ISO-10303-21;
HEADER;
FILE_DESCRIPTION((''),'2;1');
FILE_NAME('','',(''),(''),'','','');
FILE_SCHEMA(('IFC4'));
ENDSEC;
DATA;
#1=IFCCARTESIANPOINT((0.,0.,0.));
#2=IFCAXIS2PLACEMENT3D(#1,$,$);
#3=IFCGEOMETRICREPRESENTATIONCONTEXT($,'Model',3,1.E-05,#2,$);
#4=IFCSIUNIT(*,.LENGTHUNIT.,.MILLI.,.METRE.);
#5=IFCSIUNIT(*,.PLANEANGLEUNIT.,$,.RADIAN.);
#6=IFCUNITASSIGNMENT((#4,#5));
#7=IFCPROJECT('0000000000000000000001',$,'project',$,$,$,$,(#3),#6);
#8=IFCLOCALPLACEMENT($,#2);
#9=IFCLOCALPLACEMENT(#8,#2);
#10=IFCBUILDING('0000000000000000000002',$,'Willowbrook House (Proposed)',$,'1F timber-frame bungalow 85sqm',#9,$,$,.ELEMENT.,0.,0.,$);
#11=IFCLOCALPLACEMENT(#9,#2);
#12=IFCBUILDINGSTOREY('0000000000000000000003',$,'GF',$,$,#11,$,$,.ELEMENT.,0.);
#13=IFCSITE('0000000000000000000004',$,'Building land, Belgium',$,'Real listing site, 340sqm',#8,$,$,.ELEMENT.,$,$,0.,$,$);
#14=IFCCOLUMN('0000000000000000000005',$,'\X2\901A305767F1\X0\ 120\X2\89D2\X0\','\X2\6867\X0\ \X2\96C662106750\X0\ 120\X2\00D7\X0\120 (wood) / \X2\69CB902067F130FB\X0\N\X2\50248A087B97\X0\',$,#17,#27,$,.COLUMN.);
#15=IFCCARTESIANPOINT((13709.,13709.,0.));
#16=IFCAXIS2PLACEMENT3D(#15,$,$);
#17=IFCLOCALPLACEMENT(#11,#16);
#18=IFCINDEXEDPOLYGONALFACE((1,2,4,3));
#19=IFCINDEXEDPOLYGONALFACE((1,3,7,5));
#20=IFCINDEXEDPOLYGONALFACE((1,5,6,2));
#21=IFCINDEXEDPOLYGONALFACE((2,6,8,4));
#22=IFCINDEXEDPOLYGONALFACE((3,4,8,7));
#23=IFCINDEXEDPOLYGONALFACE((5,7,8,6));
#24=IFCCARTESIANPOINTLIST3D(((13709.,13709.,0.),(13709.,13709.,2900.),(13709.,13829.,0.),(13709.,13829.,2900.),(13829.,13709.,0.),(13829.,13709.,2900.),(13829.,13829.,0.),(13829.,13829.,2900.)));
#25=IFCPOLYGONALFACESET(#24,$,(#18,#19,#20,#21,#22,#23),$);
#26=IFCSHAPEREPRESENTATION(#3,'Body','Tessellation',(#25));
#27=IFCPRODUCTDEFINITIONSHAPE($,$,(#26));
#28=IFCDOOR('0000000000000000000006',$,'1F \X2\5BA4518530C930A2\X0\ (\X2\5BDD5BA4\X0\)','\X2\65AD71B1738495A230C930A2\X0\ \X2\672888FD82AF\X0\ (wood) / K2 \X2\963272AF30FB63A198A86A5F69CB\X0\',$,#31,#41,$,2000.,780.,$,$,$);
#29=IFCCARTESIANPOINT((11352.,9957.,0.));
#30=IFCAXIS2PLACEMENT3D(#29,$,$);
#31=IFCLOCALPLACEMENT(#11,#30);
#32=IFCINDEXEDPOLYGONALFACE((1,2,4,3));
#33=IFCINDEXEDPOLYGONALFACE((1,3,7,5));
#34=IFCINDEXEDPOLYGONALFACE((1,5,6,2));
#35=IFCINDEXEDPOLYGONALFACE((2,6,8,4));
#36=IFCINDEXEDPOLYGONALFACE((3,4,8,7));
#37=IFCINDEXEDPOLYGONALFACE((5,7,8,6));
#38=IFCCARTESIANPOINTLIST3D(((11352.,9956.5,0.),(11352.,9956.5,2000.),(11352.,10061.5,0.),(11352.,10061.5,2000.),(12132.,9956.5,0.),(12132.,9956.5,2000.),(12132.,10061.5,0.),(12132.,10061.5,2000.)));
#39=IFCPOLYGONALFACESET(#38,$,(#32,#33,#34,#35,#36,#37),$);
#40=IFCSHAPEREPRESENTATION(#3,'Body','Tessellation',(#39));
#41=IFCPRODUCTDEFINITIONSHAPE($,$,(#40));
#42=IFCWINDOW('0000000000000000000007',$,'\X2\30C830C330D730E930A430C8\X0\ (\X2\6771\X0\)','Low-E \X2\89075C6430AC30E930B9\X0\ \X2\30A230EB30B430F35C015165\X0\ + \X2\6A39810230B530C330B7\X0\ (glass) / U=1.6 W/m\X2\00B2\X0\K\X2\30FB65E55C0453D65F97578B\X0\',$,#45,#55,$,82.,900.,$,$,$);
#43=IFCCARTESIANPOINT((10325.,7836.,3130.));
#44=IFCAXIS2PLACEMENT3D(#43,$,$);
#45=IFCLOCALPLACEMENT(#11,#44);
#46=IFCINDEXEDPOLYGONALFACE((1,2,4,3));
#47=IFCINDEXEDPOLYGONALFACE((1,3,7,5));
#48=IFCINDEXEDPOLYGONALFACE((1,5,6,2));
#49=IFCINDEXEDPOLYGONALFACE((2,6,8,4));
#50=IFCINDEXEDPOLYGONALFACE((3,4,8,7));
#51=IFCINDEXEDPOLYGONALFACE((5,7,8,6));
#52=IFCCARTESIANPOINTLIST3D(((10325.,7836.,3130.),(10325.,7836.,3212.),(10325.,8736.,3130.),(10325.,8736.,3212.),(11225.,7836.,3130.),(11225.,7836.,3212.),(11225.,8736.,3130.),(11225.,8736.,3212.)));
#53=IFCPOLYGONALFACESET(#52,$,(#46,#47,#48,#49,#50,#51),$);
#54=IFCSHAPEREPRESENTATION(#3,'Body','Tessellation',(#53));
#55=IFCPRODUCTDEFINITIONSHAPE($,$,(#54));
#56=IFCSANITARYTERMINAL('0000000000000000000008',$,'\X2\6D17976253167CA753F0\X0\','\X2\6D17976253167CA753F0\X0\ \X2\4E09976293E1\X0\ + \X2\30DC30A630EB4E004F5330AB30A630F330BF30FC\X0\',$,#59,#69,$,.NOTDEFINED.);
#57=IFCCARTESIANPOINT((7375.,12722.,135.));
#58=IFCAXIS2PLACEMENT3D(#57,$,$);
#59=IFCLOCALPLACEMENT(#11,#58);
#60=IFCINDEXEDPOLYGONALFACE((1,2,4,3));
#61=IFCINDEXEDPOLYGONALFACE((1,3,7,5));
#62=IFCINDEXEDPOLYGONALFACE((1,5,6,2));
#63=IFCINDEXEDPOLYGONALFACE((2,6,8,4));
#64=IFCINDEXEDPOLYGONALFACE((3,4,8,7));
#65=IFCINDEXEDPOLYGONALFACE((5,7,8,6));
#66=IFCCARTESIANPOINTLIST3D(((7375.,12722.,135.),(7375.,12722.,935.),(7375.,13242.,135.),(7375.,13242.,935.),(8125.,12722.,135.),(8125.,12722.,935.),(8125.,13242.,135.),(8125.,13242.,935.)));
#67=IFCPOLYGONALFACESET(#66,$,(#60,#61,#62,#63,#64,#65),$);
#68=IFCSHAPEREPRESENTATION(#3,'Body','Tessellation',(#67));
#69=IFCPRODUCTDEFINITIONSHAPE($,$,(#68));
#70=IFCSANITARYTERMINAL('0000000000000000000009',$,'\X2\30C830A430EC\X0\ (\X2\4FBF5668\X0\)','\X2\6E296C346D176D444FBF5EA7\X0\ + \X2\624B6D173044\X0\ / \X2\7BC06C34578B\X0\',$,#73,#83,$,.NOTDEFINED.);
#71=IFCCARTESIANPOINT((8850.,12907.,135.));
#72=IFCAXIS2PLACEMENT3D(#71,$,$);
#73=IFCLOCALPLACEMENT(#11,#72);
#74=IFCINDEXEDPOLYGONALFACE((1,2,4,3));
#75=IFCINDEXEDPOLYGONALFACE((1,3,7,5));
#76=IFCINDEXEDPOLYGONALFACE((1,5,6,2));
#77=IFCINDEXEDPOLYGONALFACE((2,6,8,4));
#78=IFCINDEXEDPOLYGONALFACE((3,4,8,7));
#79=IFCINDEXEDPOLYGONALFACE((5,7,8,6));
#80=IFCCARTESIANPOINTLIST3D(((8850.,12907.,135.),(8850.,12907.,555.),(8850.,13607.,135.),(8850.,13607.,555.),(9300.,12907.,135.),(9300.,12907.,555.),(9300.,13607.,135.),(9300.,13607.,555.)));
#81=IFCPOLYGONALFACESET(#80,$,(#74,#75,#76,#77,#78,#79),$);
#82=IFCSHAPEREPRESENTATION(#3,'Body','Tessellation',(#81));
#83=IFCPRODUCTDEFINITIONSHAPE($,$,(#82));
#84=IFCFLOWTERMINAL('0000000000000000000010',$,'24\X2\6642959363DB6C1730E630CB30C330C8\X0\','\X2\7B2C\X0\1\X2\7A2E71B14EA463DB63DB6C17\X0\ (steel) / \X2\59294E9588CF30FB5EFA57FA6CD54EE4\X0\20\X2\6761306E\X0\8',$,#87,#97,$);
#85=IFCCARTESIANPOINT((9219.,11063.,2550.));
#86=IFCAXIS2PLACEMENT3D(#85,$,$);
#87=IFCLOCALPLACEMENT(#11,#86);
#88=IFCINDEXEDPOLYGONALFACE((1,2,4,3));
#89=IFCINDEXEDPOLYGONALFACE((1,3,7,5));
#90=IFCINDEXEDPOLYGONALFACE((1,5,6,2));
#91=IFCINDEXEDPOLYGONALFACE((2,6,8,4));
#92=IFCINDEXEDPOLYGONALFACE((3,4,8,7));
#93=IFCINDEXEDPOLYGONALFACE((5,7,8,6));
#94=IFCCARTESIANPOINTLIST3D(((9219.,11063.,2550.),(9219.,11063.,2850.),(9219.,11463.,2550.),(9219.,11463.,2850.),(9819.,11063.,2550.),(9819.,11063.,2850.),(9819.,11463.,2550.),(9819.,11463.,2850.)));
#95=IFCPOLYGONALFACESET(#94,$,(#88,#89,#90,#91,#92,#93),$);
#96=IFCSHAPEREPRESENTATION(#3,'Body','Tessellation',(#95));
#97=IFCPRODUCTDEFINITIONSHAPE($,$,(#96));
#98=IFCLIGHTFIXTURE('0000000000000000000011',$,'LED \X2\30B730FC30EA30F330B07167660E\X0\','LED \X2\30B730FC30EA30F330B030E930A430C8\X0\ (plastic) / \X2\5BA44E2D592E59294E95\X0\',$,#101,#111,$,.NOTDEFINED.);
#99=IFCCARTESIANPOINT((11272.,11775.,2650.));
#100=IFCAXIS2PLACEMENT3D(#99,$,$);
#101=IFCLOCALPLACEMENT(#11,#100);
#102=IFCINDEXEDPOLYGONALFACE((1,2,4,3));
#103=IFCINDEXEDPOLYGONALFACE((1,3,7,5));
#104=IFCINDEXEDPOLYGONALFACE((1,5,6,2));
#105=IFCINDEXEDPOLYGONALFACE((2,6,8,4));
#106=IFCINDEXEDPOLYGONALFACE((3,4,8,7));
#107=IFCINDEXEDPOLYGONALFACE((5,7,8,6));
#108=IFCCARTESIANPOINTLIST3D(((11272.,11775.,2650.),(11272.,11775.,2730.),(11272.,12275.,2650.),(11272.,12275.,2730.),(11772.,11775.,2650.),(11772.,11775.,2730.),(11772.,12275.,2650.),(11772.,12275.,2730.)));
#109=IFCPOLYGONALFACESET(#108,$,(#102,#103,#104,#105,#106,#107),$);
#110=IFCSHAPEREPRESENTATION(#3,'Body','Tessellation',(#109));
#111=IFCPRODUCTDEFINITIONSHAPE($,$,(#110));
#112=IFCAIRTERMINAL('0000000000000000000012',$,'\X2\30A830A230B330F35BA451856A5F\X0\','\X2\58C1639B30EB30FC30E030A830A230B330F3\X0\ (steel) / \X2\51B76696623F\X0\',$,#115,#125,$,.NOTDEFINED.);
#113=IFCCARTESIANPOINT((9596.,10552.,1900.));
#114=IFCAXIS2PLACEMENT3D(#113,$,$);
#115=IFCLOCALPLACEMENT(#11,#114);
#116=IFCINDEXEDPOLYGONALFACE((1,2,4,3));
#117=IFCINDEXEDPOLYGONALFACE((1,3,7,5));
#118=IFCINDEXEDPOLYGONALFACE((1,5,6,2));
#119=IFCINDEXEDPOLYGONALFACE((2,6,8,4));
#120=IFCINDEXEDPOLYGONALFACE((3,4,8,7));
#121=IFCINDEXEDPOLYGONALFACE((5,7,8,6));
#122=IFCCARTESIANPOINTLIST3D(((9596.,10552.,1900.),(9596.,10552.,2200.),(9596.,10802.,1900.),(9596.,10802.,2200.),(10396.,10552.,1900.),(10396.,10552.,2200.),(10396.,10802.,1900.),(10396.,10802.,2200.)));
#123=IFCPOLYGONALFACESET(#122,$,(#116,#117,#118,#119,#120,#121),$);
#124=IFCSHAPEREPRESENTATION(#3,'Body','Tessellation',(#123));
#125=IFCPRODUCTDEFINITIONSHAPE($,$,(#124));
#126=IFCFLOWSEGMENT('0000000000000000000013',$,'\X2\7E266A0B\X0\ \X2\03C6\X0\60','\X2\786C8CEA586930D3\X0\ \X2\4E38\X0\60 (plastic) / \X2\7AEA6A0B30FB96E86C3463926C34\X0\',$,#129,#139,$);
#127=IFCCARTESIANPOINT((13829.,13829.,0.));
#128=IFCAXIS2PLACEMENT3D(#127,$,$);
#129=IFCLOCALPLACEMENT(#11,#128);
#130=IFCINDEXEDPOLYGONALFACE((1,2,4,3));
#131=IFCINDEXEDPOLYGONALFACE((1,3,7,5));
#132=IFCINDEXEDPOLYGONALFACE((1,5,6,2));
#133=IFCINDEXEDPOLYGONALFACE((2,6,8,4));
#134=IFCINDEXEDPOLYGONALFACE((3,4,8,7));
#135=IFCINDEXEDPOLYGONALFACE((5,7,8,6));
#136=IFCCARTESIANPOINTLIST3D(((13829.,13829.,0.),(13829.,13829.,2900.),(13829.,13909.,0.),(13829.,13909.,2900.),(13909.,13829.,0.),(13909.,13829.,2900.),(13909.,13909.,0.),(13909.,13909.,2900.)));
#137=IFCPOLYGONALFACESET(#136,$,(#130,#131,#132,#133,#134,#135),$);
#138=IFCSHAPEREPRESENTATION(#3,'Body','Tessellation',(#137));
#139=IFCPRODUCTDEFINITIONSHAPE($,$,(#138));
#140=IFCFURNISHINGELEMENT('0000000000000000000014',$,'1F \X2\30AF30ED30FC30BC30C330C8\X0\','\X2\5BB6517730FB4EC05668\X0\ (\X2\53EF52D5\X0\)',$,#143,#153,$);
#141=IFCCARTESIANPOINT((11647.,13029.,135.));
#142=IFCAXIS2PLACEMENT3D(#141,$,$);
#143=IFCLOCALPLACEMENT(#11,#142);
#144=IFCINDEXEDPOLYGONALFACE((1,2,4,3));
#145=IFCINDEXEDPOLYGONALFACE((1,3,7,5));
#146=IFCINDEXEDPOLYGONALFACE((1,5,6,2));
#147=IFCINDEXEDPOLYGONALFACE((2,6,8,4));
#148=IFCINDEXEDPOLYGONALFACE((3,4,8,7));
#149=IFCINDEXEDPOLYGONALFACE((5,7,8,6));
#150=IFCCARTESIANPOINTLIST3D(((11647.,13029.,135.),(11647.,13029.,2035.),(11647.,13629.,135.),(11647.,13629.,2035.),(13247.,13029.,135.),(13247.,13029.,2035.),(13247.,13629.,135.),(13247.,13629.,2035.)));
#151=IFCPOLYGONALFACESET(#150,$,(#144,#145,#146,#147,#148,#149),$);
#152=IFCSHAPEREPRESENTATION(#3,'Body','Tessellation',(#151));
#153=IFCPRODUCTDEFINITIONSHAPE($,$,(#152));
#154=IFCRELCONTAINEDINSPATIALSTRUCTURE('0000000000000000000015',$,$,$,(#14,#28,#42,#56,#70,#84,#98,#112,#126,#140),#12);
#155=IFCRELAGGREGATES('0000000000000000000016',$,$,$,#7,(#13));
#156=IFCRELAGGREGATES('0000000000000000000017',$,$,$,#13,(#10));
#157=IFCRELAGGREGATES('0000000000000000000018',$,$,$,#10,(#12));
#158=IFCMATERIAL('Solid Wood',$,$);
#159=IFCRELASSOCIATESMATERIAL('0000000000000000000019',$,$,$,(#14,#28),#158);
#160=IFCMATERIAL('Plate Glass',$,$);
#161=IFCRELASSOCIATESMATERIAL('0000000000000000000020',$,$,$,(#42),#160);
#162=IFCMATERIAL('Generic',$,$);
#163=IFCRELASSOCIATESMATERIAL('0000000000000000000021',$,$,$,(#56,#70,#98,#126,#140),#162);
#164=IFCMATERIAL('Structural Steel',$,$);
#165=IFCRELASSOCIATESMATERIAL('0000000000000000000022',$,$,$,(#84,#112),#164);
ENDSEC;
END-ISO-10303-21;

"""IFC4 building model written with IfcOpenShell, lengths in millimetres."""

from ifc_helpers import new_model, si_unit, frame, frame_2d, origin, place, context, project, spatial, rectangle, extrude, material, element, save


model = new_model("IFC4")

# Units and contexts
model_context = context("Model", 3, precision=1e-05, world=origin())
ifc_project = project(units=[si_unit("LENGTHUNIT", "METRE", prefix="MILLI"), si_unit("PLANEANGLEUNIT", "RADIAN")], contexts=[model_context])

# Site, building, storey
site_placement = place(None, origin())
site = spatial("IfcSite", under=ifc_project, at=site_placement, Name="Building land, Belgium", ObjectType="Real listing site, 340sqm", CompositionType="ELEMENT", RefElevation=0.0)
building_placement = place(site_placement, origin())
building = spatial("IfcBuilding", under=site, at=building_placement, Name="Willowbrook House (Proposed)", ObjectType="1F timber-frame bungalow 85sqm", CompositionType="ELEMENT", ElevationOfRefHeight=0.0, ElevationOfTerrain=0.0)
storey_placement = place(building_placement, origin())
storey = spatial("IfcBuildingStorey", under=building, at=storey_placement, Name="GF", CompositionType="ELEMENT", Elevation=0.0)

# Column
ifc_material_1 = material(Name="Solid Wood")
column_1_placement = place(storey_placement, frame((13709.0, 13709.0, 0.0)))
element("IfcColumn", 1, at=column_1_placement, inside=storey, material=ifc_material_1, Name="通し柱 120角", Description="桧 集成材 120×120 (wood) / 構造柱・N値計算", PredefinedType="COLUMN", context=model_context, shape_type="SweptSolid", body=[
    extrude(rectangle(XDim=120.0, YDim=120.0, at=frame_2d((60.0, 60.0))), frame((13709.0, 13709.0, 0.0)), (0.0, 0.0, 1.0), 2900.0),
])

# Door
door_placement = place(storey_placement, frame((11352.0, 9957.0, 0.0)))
element("IfcDoor", 2, at=door_placement, inside=storey, material=ifc_material_1, Name="1F 室内ドア (寝室)", Description="断熱玄関ドア 木製芯 (wood) / K2 防犯・採風機構", OverallHeight=2000.0, OverallWidth=780.0, context=model_context, shape_type="SweptSolid", body=[
    extrude(rectangle(XDim=780.0, YDim=105.0, at=frame_2d((390.0, 52.0))), frame((11352.0, 9957.0, 0.0)), (0.0, 0.0, 1.0), 2000.0),
])

# Window
ifc_material_2 = material(Name="Plate Glass")
window_placement = place(storey_placement, frame((10325.0, 7836.0, 3130.0)))
element("IfcWindow", 3, at=window_placement, inside=storey, material=ifc_material_2, Name="トップライト (東)", Description="Low-E 複層ガラス アルゴン封入 + 樹脂サッシ (glass) / U=1.6 W/m²K・日射取得型", OverallHeight=82.0, OverallWidth=900.0, context=model_context, shape_type="SweptSolid", body=[
    extrude(rectangle(XDim=900.0, YDim=900.0, at=frame_2d((450.0, 450.0))), frame((10325.0, 7836.0, 3130.0)), (0.0, 0.0, 1.0), 82.0),
])

# Sanitary terminals
ifc_material_3 = material(Name="Generic")
sanitary_terminal_1_placement = place(storey_placement, frame((7375.0, 12722.0, 135.0)))
element("IfcSanitaryTerminal", 4, at=sanitary_terminal_1_placement, inside=storey, material=ifc_material_3, Name="洗面化粧台", Description="洗面化粧台 三面鏡 + ボウル一体カウンター", PredefinedType="NOTDEFINED", context=model_context, shape_type="SweptSolid", body=[
    extrude(rectangle(XDim=750.0, YDim=520.0, at=frame_2d((375.0, 260.0))), frame((7375.0, 12722.0, 135.0)), (0.0, 0.0, 1.0), 800.0),
])
sanitary_terminal_2_placement = place(storey_placement, frame((8850.0, 12907.0, 135.0)))
element("IfcSanitaryTerminal", 5, at=sanitary_terminal_2_placement, inside=storey, material=ifc_material_3, Name="トイレ (便器)", Description="温水洗浄便座 + 手洗い / 節水型", PredefinedType="NOTDEFINED", context=model_context, shape_type="SweptSolid", body=[
    extrude(rectangle(XDim=450.0, YDim=700.0, at=frame_2d((225.0, 350.0))), frame((8850.0, 12907.0, 135.0)), (0.0, 0.0, 1.0), 420.0),
])

# Flow terminal
ifc_material_4 = material(Name="Structural Steel")
flow_terminal_placement = place(storey_placement, frame((9219.0, 11063.0, 2550.0)))
element("IfcFlowTerminal", 6, at=flow_terminal_placement, inside=storey, material=ifc_material_4, Name="24時間換気ユニット", Description="第1種熱交換換気 (steel) / 天井裏・建基法令20条の8", context=model_context, shape_type="SweptSolid", body=[
    extrude(rectangle(XDim=600.0, YDim=400.0, at=frame_2d((300.0, 200.0))), frame((9219.0, 11063.0, 2550.0)), (0.0, 0.0, 1.0), 300.0),
])

# Light fixture
light_fixture_placement = place(storey_placement, frame((11272.0, 11775.0, 2650.0)))
element("IfcLightFixture", 7, at=light_fixture_placement, inside=storey, material=ifc_material_3, Name="LED シーリング照明", Description="LED シーリングライト (plastic) / 室中央天井", PredefinedType="NOTDEFINED", context=model_context, shape_type="SweptSolid", body=[
    extrude(rectangle(XDim=500.0, YDim=500.0, at=frame_2d((250.0, 250.0))), frame((11272.0, 11775.0, 2650.0)), (0.0, 0.0, 1.0), 80.0),
])

# Air terminal
air_terminal_placement = place(storey_placement, frame((9596.0, 10552.0, 1900.0)))
element("IfcAirTerminal", 8, at=air_terminal_placement, inside=storey, material=ifc_material_4, Name="エアコン室内機", Description="壁掛ルームエアコン (steel) / 冷暖房", PredefinedType="NOTDEFINED", context=model_context, shape_type="SweptSolid", body=[
    extrude(rectangle(XDim=800.0, YDim=250.0, at=frame_2d((400.0, 125.0))), frame((9596.0, 10552.0, 1900.0)), (0.0, 0.0, 1.0), 300.0),
])

# Flow segment
flow_segment_placement = place(storey_placement, frame((13829.0, 13829.0, 0.0)))
element("IfcFlowSegment", 9, at=flow_segment_placement, inside=storey, material=ifc_material_3, Name="縦樋 φ60", Description="硬質塩ビ 丸60 (plastic) / 竪樋・雨水排水", context=model_context, shape_type="SweptSolid", body=[
    extrude(rectangle(XDim=80.0, YDim=80.0, at=frame_2d((40.0, 40.0))), frame((13829.0, 13829.0, 0.0)), (0.0, 0.0, 1.0), 2900.0),
])

# Furnishing element
furnishing_placement = place(storey_placement, frame((11647.0, 13029.0, 135.0)))
element("IfcFurnishingElement", 10, at=furnishing_placement, inside=storey, material=ifc_material_3, Name="1F クローゼット", Description="家具・什器 (可動)", context=model_context, shape_type="SweptSolid", body=[
    extrude(rectangle(XDim=1600.0, YDim=600.0, at=frame_2d((800.0, 300.0))), frame((11647.0, 13029.0, 135.0)), (0.0, 0.0, 1.0), 1900.0),
])

save(model, "model.ifc")
